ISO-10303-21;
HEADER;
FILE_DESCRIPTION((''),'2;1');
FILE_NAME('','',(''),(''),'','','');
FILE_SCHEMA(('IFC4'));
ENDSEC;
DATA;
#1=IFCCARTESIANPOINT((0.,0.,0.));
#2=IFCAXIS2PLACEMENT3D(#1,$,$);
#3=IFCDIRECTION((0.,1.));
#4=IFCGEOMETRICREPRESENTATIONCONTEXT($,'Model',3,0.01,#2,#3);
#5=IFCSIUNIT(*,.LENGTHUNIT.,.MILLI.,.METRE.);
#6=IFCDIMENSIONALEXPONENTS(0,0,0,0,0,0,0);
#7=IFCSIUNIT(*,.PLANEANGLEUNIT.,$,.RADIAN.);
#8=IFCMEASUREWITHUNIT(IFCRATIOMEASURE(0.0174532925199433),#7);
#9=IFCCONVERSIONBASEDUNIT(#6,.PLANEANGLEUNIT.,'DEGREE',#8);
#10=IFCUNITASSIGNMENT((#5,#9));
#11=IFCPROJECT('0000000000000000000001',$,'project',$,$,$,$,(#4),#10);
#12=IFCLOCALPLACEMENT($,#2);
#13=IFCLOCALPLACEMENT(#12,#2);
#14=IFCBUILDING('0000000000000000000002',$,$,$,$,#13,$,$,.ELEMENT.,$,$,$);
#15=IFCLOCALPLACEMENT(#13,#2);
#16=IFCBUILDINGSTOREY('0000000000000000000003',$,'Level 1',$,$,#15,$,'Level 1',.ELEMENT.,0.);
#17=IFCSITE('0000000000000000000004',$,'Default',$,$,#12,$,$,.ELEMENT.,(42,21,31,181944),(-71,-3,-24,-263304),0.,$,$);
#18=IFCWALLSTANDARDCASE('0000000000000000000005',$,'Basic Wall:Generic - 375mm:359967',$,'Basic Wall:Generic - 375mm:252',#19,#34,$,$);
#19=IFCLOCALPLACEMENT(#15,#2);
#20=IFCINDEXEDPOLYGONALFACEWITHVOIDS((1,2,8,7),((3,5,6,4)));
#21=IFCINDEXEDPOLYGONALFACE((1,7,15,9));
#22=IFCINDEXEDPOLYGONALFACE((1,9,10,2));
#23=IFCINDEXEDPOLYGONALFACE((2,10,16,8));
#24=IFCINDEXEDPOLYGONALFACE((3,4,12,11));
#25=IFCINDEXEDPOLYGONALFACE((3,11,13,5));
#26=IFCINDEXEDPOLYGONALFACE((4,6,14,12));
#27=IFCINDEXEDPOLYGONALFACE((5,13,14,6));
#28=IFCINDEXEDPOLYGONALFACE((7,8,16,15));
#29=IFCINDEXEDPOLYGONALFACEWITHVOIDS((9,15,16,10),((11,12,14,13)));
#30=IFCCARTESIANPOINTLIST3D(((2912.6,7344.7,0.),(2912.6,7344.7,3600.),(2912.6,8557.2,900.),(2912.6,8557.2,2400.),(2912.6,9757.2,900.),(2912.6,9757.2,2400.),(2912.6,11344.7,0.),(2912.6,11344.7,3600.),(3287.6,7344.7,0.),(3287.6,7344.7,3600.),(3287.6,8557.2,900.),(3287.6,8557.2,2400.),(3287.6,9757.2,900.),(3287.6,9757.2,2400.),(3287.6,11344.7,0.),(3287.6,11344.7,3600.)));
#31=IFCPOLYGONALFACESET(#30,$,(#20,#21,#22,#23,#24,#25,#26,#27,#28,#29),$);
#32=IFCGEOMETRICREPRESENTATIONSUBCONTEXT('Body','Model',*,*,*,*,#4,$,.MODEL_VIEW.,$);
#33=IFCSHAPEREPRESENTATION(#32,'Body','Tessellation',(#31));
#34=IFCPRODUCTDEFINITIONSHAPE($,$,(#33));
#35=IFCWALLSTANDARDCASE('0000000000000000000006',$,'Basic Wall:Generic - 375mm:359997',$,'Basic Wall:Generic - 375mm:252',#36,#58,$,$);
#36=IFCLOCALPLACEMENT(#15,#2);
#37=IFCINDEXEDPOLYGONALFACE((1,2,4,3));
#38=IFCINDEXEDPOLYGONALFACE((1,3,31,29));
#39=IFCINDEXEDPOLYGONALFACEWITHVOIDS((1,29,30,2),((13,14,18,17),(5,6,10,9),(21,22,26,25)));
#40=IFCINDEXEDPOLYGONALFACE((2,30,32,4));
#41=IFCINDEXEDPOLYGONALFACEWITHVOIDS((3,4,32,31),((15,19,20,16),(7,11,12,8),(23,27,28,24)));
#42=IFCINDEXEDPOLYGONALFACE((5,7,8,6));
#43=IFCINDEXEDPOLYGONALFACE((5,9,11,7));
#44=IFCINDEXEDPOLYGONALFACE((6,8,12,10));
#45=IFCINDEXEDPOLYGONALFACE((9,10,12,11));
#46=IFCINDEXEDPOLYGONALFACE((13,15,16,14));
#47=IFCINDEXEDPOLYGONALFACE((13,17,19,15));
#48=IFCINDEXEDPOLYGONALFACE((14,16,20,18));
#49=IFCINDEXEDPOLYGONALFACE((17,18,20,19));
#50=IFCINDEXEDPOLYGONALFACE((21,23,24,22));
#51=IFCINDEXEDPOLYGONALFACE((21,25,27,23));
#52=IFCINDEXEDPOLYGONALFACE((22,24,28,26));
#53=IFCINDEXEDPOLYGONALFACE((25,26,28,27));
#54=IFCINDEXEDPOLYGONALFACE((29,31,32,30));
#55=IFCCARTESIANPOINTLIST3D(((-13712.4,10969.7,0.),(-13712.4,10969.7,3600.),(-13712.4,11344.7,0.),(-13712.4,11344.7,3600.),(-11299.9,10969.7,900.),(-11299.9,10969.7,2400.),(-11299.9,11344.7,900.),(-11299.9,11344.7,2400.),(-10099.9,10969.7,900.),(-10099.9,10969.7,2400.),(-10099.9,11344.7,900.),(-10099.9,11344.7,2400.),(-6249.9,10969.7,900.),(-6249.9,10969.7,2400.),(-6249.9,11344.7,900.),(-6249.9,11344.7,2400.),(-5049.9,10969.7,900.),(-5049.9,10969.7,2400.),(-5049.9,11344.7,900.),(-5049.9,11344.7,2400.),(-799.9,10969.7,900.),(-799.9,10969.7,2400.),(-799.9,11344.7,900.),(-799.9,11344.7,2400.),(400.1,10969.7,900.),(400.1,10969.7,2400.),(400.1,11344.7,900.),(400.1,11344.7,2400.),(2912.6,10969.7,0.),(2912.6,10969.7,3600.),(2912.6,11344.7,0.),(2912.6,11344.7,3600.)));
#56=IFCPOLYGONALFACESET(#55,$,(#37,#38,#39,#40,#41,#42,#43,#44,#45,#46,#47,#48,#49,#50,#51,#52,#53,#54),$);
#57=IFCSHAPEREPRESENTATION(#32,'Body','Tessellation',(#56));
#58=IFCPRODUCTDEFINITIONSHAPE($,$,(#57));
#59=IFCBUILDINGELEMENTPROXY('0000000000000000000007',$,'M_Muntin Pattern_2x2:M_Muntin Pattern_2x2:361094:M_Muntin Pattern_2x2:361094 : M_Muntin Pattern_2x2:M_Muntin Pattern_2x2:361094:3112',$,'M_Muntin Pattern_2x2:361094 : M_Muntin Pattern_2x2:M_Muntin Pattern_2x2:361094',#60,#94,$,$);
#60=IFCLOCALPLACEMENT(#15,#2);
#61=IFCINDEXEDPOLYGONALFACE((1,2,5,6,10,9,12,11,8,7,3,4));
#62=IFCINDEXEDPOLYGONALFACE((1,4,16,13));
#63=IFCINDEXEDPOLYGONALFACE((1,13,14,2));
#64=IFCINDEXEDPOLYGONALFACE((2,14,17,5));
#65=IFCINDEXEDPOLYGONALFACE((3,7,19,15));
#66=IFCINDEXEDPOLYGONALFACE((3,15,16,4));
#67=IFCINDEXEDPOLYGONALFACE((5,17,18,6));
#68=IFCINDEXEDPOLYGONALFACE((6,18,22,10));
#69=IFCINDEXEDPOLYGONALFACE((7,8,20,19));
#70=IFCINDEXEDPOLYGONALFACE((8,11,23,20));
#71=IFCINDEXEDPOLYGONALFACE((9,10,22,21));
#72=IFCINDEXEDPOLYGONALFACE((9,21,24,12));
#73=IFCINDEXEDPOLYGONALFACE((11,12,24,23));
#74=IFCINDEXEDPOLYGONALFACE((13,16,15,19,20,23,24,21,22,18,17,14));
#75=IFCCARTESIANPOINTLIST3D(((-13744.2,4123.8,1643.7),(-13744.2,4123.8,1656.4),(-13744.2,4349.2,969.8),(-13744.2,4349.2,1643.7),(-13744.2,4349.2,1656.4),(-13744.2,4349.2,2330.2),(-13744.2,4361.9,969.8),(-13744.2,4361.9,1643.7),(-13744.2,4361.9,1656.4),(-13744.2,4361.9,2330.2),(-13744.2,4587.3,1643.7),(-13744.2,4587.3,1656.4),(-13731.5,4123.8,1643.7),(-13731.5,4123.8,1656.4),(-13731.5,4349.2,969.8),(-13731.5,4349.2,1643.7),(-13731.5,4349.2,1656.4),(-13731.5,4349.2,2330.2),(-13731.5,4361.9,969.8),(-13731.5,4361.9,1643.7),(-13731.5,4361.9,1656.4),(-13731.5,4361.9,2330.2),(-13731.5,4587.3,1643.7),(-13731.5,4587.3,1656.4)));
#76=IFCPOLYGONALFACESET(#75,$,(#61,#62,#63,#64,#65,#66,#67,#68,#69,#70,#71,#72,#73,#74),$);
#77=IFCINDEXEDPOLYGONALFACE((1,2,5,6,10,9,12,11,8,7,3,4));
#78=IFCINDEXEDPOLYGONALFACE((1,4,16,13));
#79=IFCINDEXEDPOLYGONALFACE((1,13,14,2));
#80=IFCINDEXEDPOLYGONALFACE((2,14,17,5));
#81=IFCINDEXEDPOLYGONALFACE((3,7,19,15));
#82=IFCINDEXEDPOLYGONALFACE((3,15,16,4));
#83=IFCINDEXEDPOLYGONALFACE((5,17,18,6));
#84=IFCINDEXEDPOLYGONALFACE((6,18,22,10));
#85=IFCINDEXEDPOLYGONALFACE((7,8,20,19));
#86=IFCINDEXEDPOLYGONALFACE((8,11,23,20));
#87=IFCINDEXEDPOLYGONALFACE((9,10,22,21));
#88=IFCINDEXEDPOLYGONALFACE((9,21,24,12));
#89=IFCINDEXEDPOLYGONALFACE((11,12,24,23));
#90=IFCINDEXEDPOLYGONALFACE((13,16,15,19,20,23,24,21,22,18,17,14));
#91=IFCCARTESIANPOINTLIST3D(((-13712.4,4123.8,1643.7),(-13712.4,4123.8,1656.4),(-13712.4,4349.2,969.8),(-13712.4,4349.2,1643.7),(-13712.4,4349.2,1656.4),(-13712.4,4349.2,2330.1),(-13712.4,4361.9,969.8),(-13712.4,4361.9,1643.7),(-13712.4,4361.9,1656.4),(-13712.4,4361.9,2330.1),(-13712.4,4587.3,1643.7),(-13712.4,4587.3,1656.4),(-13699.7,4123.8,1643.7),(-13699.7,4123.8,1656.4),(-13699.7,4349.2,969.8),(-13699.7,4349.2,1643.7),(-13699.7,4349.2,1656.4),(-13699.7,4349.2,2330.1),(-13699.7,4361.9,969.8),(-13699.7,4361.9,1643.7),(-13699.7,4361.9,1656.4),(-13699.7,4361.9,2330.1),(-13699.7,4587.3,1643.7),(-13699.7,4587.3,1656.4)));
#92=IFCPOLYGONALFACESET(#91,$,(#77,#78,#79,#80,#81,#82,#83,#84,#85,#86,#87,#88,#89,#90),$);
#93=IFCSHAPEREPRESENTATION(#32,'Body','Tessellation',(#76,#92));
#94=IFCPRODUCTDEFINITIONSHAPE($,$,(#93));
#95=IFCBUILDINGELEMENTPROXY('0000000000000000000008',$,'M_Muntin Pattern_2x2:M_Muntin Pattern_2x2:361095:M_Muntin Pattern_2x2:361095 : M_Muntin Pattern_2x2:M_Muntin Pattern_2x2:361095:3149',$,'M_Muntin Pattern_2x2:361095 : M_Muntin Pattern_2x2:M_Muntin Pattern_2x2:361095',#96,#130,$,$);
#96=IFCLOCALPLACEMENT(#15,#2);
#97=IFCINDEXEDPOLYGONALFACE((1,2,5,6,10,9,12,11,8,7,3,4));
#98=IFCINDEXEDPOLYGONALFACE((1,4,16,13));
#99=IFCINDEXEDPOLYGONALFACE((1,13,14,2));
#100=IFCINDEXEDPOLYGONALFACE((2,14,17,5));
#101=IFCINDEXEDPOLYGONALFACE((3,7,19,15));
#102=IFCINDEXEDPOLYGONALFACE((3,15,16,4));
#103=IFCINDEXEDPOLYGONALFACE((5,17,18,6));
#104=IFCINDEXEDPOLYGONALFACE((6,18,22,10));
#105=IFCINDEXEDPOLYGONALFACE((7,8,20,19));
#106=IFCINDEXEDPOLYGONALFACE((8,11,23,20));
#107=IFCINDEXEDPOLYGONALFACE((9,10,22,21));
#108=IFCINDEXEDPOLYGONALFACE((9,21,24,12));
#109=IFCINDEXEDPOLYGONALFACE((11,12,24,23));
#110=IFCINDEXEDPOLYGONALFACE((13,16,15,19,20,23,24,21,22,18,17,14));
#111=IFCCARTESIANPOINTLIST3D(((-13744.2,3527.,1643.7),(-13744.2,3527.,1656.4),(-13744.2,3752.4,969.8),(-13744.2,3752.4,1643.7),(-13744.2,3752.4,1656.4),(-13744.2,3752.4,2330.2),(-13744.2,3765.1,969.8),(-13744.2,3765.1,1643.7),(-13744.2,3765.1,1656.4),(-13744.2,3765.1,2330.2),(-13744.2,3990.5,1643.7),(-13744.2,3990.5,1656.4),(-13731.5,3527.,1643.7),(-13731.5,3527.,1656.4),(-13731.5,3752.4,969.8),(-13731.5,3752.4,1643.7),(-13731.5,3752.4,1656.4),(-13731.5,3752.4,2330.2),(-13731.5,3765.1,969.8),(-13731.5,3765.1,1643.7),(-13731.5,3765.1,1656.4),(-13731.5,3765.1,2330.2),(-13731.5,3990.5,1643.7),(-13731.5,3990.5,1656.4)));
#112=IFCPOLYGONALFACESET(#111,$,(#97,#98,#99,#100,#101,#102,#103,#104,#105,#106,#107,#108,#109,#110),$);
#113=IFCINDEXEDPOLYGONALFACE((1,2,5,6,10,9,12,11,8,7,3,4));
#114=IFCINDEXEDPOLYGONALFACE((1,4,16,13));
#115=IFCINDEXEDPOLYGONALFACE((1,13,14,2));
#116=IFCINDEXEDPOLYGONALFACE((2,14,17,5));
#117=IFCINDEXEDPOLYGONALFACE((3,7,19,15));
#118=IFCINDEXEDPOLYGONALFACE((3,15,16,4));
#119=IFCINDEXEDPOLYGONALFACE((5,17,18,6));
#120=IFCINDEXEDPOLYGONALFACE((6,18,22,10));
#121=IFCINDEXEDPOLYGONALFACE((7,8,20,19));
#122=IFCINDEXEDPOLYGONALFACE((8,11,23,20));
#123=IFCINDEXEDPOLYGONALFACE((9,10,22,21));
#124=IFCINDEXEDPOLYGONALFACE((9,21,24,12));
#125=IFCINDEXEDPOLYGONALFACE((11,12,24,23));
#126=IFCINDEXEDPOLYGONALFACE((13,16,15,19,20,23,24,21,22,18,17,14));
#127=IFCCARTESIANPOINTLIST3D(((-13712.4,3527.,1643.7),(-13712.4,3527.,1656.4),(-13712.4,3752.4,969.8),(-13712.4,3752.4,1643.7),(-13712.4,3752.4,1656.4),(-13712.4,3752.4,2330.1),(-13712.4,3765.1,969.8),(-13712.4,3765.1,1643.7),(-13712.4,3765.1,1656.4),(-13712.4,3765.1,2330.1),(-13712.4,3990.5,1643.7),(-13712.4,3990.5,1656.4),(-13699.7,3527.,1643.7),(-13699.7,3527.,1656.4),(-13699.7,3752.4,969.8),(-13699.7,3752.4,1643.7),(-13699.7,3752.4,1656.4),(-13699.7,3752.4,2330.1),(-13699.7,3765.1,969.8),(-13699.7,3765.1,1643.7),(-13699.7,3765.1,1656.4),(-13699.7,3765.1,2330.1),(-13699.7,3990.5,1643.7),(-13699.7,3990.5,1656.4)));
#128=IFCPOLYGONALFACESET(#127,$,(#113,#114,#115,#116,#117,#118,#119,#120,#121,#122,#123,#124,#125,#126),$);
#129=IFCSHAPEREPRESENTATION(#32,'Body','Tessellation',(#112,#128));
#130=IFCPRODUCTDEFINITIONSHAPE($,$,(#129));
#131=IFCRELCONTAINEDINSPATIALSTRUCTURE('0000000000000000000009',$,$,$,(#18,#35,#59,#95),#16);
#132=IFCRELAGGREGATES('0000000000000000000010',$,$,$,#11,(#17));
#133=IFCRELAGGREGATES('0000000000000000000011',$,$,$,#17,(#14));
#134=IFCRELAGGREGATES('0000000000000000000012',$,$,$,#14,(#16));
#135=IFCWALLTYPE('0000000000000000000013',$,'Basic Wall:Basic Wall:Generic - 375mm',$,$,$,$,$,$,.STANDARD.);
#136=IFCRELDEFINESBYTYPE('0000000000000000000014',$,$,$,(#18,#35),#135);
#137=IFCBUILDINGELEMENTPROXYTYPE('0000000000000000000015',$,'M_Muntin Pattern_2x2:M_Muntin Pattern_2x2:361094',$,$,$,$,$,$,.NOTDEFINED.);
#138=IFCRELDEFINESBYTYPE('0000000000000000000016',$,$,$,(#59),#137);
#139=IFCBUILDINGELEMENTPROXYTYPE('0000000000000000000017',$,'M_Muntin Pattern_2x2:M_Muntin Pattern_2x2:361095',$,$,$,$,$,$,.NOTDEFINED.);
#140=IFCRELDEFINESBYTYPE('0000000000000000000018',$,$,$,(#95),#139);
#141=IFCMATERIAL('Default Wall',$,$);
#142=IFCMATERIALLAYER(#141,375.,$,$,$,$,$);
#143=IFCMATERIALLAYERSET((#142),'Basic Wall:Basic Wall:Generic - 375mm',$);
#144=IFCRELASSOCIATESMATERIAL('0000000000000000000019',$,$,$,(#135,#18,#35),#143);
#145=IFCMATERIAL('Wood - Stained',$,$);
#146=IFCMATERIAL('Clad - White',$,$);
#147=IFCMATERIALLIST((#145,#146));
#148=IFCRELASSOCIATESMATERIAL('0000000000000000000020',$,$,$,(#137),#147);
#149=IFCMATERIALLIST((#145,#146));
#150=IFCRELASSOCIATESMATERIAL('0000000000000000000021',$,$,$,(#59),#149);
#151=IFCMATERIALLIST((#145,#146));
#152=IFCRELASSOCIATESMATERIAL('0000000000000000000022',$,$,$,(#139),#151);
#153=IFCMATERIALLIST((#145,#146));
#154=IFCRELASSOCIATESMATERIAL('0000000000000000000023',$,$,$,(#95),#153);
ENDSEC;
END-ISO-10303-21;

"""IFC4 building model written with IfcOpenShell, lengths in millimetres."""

from ifc_helpers import new_model, entity, si_unit, converted_unit, direction, frame, frame_2d, origin, place, context, subcontext, project, spatial, polyline, rectangle, outline, extrude, source, transform, mapped, material, material_list, layer, layer_set, layer_usage, type_object, type_shapes, element, save


model = new_model("IFC4")

# Units and contexts
model_context = context("Model", 3, precision=0.01, world=origin(), true_north=direction((0.0, 1.0)))
body_context = subcontext(model_context, "Body", "Model", "MODEL_VIEW")
ifc_project = project(units=[si_unit("LENGTHUNIT", "METRE", prefix="MILLI"), converted_unit("PLANEANGLEUNIT", "DEGREE", entity("IfcRatioMeasure", 0.0174532925199433), si_unit("PLANEANGLEUNIT", "RADIAN"), dimensions=[0, 0, 0, 0, 0, 0, 0])], contexts=[model_context])

# Site, building, storey
site_placement = place(None, origin())
site = spatial("IfcSite", under=ifc_project, at=site_placement, Name="Default", CompositionType="ELEMENT", RefLatitude=(42, 21, 31, 181944), RefLongitude=(-71, -3, -24, -263304), RefElevation=0.0)
building_placement = place(site_placement, origin())
building = spatial("IfcBuilding", under=site, at=building_placement, CompositionType="ELEMENT")
storey_placement = place(building_placement, origin())
storey = spatial("IfcBuildingStorey", under=building, at=storey_placement, Name="Level 1", LongName="Level 1", CompositionType="ELEMENT", Elevation=0.0)

# Wall, opening
ifc_material_1 = material(Name="Default Wall")
ifc_layer = layer(ifc_material_1, 375.0)
ifc_layer_set = layer_set([ifc_layer], Name="Basic Wall:Basic Wall:Generic - 375mm")
ifc_layer_usage_1 = layer_usage(ifc_layer_set, "AXIS2", "NEGATIVE", 187.5)
wall_type = type_object("IfcWallType", Name="Basic Wall:Basic Wall:Generic - 375mm", PredefinedType="STANDARD", material=ifc_layer_set)
wall_1_placement = place(storey_placement, frame((3100.1, 7344.7, 0.0), z_axis=(0.0, 0.0, 1.0), x_axis=(0.0, 1.0, 0.0)))
wall_1 = element("IfcWallStandardCase", 1, at=wall_1_placement, inside=storey, type_object=wall_type, material=ifc_layer_usage_1, Name="Basic Wall:Generic - 375mm:359967", ObjectType="Basic Wall:Generic - 375mm:252", context=body_context, shape_type="SweptSolid", body=[
    extrude(rectangle(XDim=4000.0, YDim=375.0, at=frame_2d((2000.0, 0.0), x_axis=(-1.0, 0.0))), origin(), (0.0, 0.0, 1.0), 3600.0),
])
opening_1_placement = place(wall_1_placement, frame((-7344.7, 3100.1, 0.0), z_axis=(0.0, 0.0, 1.0), x_axis=(0.0, -1.0, 0.0)))
element("IfcOpeningElement", 2, at=opening_1_placement, cuts=wall_1, ObjectType="Opening", context=body_context, shape_type="SweptSolid", body=[
    extrude(rectangle(XDim=1500.0, YDim=1200.0, at=frame_2d((0.0, 0.0), x_axis=(0.0, 1.0))), frame((3291.3, 9157.2, 1650.0), z_axis=(-1.0, 0.0, 0.0), x_axis=(0.0, -1.0, 0.0)), (0.0, 0.0, 1.0), 382.5),
])

# Wall, openings
ifc_layer_usage_2 = layer_usage(ifc_layer_set, "AXIS2", "NEGATIVE", 187.5)
wall_2_placement = place(storey_placement, frame((2912.6, 11157.2, 0.0), z_axis=(0.0, 0.0, 1.0), x_axis=(-1.0, 0.0, 0.0)))
wall_2 = element("IfcWallStandardCase", 3, at=wall_2_placement, inside=storey, type_object=wall_type, material=ifc_layer_usage_2, Name="Basic Wall:Generic - 375mm:359997", ObjectType="Basic Wall:Generic - 375mm:252", context=body_context, shape_type="SweptSolid", body=[
    extrude(rectangle(XDim=16625.0, YDim=375.0, at=frame_2d((8312.5, 0.0), x_axis=(-1.0, 0.0))), origin(), (0.0, 0.0, 1.0), 3600.0),
])
opening_2_placement = place(wall_2_placement, frame((2912.6, 11157.2, 0.0), z_axis=(0.0, 0.0, 1.0), x_axis=(-1.0, 0.0, 0.0)))
element("IfcOpeningElement", 4, at=opening_2_placement, cuts=wall_2, ObjectType="Opening", context=body_context, shape_type="SweptSolid", body=[
    extrude(rectangle(XDim=1500.0, YDim=1200.0, at=frame_2d((0.0, 0.0), x_axis=(0.0, 1.0))), frame((-5649.9, 11348.4, 1650.0), z_axis=(0.0, -1.0, 0.0), x_axis=(1.0, 0.0, 0.0)), (0.0, 0.0, 1.0), 382.5),
])
opening_3_placement = place(wall_2_placement, frame((2912.6, 11157.2, 0.0), z_axis=(0.0, 0.0, 1.0), x_axis=(-1.0, 0.0, 0.0)))
element("IfcOpeningElement", 5, at=opening_3_placement, cuts=wall_2, ObjectType="Opening", context=body_context, shape_type="SweptSolid", body=[
    extrude(rectangle(XDim=1500.0, YDim=1200.0, at=frame_2d((0.0, 0.0), x_axis=(0.0, 1.0))), frame((-199.9, 11348.4, 1650.0), z_axis=(0.0, -1.0, 0.0), x_axis=(1.0, 0.0, 0.0)), (0.0, 0.0, 1.0), 382.5),
])
opening_4_placement = place(wall_2_placement, frame((2912.6, 11157.2, 0.0), z_axis=(0.0, 0.0, 1.0), x_axis=(-1.0, 0.0, 0.0)))
element("IfcOpeningElement", 6, at=opening_4_placement, cuts=wall_2, ObjectType="Opening", context=body_context, shape_type="SweptSolid", body=[
    extrude(rectangle(XDim=1500.0, YDim=1200.0, at=frame_2d((0.0, 0.0), x_axis=(0.0, 1.0))), frame((-10699.9, 11348.4, 1650.0), z_axis=(0.0, -1.0, 0.0), x_axis=(1.0, 0.0, 0.0)), (0.0, 0.0, 1.0), 382.5),
])

# Building element proxies
ifc_material_2 = material(Name="Wood - Stained")
ifc_material_3 = material(Name="Clad - White")
ifc_material_list_1 = material_list([ifc_material_2, ifc_material_3])
ifc_material_list_2 = material_list([ifc_material_2, ifc_material_3])
building_element_proxy_type_1 = type_object("IfcBuildingElementProxyType", Name="M_Muntin Pattern_2x2:M_Muntin Pattern_2x2:361094", PredefinedType="NOTDEFINED", material=ifc_material_list_2)
shared_shape_1 = source(origin(), body_context, "Body", "SweptSolid", [
    extrude(outline(polyline([(-6.4, -680.2), (6.3, -680.2), (6.3, -6.4), (231.7, -6.4), (231.7, 6.3), (6.3, 6.3), (6.3, 680.2), (-6.4, 680.2), (-6.4, 6.3), (-231.7, 6.3), (-231.7, -6.4), (-6.4, -6.4), (-6.4, -680.2)])), frame((-13744.2, 4355.6, 1650.0), z_axis=(1.0, 0.0, 0.0), x_axis=(0.0, -1.0, 0.0)), (0.0, 0.0, 1.0), 12.7),
    extrude(outline(polyline([(-6.4, -680.1), (6.3, -680.1), (6.3, -6.4), (231.7, -6.4), (231.7, 6.3), (6.3, 6.3), (6.3, 680.2), (-6.4, 680.2), (-6.4, 6.3), (-231.7, 6.3), (-231.7, -6.4), (-6.4, -6.4), (-6.4, -680.1)])), frame((-13712.4, 4355.6, 1650.0), z_axis=(1.0, 0.0, 0.0), x_axis=(0.0, -1.0, 0.0)), (0.0, 0.0, 1.0), 12.7),
])
type_shapes(building_element_proxy_type_1, [shared_shape_1])
proxy_1_placement = place(storey_placement, origin())
element("IfcBuildingElementProxy", 7, at=proxy_1_placement, inside=storey, type_object=building_element_proxy_type_1, material=ifc_material_list_1, Name="M_Muntin Pattern_2x2:M_Muntin Pattern_2x2:361094:M_Muntin Pattern_2x2:361094 : M_Muntin Pattern_2x2:M_Muntin Pattern_2x2:361094:3112", ObjectType="M_Muntin Pattern_2x2:361094 : M_Muntin Pattern_2x2:M_Muntin Pattern_2x2:361094", context=body_context, shape_type="MappedRepresentation", body=[
    mapped(shared_shape_1, transform((0.0, 0.0, 0.0), scale=1.0)),
])
ifc_material_list_3 = material_list([ifc_material_2, ifc_material_3])
ifc_material_list_4 = material_list([ifc_material_2, ifc_material_3])
building_element_proxy_type_2 = type_object("IfcBuildingElementProxyType", Name="M_Muntin Pattern_2x2:M_Muntin Pattern_2x2:361095", PredefinedType="NOTDEFINED", material=ifc_material_list_4)
shared_shape_2 = source(origin(), body_context, "Body", "SweptSolid", [
    extrude(outline(polyline([(-680.1, 6.4), (-680.1, -6.3), (-6.4, -6.3), (-6.4, -231.7), (6.3, -231.7), (6.3, -6.3), (680.2, -6.3), (680.2, 6.4), (6.3, 6.4), (6.3, 231.7), (-6.4, 231.7), (-6.4, 6.4), (-680.1, 6.4)])), frame((-13744.2, 3758.7, 1650.0), z_axis=(-1.0, 0.0, 0.0), x_axis=(0.0, 0.0, -1.0)), (0.0, 0.0, -1.0), 12.7),
    extrude(outline(polyline([(-680.1, 6.4), (-680.1, -6.3), (-6.4, -6.3), (-6.4, -231.7), (6.3, -231.7), (6.3, -6.3), (680.2, -6.3), (680.2, 6.4), (6.3, 6.4), (6.3, 231.7), (-6.4, 231.7), (-6.4, 6.4), (-680.1, 6.4)])), frame((-13712.4, 3758.7, 1650.0), z_axis=(-1.0, 0.0, 0.0), x_axis=(0.0, 0.0, -1.0)), (0.0, 0.0, -1.0), 12.7),
])
type_shapes(building_element_proxy_type_2, [shared_shape_2])
proxy_2_placement = place(storey_placement, origin())
element("IfcBuildingElementProxy", 8, at=proxy_2_placement, inside=storey, type_object=building_element_proxy_type_2, material=ifc_material_list_3, Name="M_Muntin Pattern_2x2:M_Muntin Pattern_2x2:361095:M_Muntin Pattern_2x2:361095 : M_Muntin Pattern_2x2:M_Muntin Pattern_2x2:361095:3149", ObjectType="M_Muntin Pattern_2x2:361095 : M_Muntin Pattern_2x2:M_Muntin Pattern_2x2:361095", context=body_context, shape_type="MappedRepresentation", body=[
    mapped(shared_shape_2, transform((0.0, 0.0, 0.0), scale=1.0)),
])

save(model, "model.ifc")
